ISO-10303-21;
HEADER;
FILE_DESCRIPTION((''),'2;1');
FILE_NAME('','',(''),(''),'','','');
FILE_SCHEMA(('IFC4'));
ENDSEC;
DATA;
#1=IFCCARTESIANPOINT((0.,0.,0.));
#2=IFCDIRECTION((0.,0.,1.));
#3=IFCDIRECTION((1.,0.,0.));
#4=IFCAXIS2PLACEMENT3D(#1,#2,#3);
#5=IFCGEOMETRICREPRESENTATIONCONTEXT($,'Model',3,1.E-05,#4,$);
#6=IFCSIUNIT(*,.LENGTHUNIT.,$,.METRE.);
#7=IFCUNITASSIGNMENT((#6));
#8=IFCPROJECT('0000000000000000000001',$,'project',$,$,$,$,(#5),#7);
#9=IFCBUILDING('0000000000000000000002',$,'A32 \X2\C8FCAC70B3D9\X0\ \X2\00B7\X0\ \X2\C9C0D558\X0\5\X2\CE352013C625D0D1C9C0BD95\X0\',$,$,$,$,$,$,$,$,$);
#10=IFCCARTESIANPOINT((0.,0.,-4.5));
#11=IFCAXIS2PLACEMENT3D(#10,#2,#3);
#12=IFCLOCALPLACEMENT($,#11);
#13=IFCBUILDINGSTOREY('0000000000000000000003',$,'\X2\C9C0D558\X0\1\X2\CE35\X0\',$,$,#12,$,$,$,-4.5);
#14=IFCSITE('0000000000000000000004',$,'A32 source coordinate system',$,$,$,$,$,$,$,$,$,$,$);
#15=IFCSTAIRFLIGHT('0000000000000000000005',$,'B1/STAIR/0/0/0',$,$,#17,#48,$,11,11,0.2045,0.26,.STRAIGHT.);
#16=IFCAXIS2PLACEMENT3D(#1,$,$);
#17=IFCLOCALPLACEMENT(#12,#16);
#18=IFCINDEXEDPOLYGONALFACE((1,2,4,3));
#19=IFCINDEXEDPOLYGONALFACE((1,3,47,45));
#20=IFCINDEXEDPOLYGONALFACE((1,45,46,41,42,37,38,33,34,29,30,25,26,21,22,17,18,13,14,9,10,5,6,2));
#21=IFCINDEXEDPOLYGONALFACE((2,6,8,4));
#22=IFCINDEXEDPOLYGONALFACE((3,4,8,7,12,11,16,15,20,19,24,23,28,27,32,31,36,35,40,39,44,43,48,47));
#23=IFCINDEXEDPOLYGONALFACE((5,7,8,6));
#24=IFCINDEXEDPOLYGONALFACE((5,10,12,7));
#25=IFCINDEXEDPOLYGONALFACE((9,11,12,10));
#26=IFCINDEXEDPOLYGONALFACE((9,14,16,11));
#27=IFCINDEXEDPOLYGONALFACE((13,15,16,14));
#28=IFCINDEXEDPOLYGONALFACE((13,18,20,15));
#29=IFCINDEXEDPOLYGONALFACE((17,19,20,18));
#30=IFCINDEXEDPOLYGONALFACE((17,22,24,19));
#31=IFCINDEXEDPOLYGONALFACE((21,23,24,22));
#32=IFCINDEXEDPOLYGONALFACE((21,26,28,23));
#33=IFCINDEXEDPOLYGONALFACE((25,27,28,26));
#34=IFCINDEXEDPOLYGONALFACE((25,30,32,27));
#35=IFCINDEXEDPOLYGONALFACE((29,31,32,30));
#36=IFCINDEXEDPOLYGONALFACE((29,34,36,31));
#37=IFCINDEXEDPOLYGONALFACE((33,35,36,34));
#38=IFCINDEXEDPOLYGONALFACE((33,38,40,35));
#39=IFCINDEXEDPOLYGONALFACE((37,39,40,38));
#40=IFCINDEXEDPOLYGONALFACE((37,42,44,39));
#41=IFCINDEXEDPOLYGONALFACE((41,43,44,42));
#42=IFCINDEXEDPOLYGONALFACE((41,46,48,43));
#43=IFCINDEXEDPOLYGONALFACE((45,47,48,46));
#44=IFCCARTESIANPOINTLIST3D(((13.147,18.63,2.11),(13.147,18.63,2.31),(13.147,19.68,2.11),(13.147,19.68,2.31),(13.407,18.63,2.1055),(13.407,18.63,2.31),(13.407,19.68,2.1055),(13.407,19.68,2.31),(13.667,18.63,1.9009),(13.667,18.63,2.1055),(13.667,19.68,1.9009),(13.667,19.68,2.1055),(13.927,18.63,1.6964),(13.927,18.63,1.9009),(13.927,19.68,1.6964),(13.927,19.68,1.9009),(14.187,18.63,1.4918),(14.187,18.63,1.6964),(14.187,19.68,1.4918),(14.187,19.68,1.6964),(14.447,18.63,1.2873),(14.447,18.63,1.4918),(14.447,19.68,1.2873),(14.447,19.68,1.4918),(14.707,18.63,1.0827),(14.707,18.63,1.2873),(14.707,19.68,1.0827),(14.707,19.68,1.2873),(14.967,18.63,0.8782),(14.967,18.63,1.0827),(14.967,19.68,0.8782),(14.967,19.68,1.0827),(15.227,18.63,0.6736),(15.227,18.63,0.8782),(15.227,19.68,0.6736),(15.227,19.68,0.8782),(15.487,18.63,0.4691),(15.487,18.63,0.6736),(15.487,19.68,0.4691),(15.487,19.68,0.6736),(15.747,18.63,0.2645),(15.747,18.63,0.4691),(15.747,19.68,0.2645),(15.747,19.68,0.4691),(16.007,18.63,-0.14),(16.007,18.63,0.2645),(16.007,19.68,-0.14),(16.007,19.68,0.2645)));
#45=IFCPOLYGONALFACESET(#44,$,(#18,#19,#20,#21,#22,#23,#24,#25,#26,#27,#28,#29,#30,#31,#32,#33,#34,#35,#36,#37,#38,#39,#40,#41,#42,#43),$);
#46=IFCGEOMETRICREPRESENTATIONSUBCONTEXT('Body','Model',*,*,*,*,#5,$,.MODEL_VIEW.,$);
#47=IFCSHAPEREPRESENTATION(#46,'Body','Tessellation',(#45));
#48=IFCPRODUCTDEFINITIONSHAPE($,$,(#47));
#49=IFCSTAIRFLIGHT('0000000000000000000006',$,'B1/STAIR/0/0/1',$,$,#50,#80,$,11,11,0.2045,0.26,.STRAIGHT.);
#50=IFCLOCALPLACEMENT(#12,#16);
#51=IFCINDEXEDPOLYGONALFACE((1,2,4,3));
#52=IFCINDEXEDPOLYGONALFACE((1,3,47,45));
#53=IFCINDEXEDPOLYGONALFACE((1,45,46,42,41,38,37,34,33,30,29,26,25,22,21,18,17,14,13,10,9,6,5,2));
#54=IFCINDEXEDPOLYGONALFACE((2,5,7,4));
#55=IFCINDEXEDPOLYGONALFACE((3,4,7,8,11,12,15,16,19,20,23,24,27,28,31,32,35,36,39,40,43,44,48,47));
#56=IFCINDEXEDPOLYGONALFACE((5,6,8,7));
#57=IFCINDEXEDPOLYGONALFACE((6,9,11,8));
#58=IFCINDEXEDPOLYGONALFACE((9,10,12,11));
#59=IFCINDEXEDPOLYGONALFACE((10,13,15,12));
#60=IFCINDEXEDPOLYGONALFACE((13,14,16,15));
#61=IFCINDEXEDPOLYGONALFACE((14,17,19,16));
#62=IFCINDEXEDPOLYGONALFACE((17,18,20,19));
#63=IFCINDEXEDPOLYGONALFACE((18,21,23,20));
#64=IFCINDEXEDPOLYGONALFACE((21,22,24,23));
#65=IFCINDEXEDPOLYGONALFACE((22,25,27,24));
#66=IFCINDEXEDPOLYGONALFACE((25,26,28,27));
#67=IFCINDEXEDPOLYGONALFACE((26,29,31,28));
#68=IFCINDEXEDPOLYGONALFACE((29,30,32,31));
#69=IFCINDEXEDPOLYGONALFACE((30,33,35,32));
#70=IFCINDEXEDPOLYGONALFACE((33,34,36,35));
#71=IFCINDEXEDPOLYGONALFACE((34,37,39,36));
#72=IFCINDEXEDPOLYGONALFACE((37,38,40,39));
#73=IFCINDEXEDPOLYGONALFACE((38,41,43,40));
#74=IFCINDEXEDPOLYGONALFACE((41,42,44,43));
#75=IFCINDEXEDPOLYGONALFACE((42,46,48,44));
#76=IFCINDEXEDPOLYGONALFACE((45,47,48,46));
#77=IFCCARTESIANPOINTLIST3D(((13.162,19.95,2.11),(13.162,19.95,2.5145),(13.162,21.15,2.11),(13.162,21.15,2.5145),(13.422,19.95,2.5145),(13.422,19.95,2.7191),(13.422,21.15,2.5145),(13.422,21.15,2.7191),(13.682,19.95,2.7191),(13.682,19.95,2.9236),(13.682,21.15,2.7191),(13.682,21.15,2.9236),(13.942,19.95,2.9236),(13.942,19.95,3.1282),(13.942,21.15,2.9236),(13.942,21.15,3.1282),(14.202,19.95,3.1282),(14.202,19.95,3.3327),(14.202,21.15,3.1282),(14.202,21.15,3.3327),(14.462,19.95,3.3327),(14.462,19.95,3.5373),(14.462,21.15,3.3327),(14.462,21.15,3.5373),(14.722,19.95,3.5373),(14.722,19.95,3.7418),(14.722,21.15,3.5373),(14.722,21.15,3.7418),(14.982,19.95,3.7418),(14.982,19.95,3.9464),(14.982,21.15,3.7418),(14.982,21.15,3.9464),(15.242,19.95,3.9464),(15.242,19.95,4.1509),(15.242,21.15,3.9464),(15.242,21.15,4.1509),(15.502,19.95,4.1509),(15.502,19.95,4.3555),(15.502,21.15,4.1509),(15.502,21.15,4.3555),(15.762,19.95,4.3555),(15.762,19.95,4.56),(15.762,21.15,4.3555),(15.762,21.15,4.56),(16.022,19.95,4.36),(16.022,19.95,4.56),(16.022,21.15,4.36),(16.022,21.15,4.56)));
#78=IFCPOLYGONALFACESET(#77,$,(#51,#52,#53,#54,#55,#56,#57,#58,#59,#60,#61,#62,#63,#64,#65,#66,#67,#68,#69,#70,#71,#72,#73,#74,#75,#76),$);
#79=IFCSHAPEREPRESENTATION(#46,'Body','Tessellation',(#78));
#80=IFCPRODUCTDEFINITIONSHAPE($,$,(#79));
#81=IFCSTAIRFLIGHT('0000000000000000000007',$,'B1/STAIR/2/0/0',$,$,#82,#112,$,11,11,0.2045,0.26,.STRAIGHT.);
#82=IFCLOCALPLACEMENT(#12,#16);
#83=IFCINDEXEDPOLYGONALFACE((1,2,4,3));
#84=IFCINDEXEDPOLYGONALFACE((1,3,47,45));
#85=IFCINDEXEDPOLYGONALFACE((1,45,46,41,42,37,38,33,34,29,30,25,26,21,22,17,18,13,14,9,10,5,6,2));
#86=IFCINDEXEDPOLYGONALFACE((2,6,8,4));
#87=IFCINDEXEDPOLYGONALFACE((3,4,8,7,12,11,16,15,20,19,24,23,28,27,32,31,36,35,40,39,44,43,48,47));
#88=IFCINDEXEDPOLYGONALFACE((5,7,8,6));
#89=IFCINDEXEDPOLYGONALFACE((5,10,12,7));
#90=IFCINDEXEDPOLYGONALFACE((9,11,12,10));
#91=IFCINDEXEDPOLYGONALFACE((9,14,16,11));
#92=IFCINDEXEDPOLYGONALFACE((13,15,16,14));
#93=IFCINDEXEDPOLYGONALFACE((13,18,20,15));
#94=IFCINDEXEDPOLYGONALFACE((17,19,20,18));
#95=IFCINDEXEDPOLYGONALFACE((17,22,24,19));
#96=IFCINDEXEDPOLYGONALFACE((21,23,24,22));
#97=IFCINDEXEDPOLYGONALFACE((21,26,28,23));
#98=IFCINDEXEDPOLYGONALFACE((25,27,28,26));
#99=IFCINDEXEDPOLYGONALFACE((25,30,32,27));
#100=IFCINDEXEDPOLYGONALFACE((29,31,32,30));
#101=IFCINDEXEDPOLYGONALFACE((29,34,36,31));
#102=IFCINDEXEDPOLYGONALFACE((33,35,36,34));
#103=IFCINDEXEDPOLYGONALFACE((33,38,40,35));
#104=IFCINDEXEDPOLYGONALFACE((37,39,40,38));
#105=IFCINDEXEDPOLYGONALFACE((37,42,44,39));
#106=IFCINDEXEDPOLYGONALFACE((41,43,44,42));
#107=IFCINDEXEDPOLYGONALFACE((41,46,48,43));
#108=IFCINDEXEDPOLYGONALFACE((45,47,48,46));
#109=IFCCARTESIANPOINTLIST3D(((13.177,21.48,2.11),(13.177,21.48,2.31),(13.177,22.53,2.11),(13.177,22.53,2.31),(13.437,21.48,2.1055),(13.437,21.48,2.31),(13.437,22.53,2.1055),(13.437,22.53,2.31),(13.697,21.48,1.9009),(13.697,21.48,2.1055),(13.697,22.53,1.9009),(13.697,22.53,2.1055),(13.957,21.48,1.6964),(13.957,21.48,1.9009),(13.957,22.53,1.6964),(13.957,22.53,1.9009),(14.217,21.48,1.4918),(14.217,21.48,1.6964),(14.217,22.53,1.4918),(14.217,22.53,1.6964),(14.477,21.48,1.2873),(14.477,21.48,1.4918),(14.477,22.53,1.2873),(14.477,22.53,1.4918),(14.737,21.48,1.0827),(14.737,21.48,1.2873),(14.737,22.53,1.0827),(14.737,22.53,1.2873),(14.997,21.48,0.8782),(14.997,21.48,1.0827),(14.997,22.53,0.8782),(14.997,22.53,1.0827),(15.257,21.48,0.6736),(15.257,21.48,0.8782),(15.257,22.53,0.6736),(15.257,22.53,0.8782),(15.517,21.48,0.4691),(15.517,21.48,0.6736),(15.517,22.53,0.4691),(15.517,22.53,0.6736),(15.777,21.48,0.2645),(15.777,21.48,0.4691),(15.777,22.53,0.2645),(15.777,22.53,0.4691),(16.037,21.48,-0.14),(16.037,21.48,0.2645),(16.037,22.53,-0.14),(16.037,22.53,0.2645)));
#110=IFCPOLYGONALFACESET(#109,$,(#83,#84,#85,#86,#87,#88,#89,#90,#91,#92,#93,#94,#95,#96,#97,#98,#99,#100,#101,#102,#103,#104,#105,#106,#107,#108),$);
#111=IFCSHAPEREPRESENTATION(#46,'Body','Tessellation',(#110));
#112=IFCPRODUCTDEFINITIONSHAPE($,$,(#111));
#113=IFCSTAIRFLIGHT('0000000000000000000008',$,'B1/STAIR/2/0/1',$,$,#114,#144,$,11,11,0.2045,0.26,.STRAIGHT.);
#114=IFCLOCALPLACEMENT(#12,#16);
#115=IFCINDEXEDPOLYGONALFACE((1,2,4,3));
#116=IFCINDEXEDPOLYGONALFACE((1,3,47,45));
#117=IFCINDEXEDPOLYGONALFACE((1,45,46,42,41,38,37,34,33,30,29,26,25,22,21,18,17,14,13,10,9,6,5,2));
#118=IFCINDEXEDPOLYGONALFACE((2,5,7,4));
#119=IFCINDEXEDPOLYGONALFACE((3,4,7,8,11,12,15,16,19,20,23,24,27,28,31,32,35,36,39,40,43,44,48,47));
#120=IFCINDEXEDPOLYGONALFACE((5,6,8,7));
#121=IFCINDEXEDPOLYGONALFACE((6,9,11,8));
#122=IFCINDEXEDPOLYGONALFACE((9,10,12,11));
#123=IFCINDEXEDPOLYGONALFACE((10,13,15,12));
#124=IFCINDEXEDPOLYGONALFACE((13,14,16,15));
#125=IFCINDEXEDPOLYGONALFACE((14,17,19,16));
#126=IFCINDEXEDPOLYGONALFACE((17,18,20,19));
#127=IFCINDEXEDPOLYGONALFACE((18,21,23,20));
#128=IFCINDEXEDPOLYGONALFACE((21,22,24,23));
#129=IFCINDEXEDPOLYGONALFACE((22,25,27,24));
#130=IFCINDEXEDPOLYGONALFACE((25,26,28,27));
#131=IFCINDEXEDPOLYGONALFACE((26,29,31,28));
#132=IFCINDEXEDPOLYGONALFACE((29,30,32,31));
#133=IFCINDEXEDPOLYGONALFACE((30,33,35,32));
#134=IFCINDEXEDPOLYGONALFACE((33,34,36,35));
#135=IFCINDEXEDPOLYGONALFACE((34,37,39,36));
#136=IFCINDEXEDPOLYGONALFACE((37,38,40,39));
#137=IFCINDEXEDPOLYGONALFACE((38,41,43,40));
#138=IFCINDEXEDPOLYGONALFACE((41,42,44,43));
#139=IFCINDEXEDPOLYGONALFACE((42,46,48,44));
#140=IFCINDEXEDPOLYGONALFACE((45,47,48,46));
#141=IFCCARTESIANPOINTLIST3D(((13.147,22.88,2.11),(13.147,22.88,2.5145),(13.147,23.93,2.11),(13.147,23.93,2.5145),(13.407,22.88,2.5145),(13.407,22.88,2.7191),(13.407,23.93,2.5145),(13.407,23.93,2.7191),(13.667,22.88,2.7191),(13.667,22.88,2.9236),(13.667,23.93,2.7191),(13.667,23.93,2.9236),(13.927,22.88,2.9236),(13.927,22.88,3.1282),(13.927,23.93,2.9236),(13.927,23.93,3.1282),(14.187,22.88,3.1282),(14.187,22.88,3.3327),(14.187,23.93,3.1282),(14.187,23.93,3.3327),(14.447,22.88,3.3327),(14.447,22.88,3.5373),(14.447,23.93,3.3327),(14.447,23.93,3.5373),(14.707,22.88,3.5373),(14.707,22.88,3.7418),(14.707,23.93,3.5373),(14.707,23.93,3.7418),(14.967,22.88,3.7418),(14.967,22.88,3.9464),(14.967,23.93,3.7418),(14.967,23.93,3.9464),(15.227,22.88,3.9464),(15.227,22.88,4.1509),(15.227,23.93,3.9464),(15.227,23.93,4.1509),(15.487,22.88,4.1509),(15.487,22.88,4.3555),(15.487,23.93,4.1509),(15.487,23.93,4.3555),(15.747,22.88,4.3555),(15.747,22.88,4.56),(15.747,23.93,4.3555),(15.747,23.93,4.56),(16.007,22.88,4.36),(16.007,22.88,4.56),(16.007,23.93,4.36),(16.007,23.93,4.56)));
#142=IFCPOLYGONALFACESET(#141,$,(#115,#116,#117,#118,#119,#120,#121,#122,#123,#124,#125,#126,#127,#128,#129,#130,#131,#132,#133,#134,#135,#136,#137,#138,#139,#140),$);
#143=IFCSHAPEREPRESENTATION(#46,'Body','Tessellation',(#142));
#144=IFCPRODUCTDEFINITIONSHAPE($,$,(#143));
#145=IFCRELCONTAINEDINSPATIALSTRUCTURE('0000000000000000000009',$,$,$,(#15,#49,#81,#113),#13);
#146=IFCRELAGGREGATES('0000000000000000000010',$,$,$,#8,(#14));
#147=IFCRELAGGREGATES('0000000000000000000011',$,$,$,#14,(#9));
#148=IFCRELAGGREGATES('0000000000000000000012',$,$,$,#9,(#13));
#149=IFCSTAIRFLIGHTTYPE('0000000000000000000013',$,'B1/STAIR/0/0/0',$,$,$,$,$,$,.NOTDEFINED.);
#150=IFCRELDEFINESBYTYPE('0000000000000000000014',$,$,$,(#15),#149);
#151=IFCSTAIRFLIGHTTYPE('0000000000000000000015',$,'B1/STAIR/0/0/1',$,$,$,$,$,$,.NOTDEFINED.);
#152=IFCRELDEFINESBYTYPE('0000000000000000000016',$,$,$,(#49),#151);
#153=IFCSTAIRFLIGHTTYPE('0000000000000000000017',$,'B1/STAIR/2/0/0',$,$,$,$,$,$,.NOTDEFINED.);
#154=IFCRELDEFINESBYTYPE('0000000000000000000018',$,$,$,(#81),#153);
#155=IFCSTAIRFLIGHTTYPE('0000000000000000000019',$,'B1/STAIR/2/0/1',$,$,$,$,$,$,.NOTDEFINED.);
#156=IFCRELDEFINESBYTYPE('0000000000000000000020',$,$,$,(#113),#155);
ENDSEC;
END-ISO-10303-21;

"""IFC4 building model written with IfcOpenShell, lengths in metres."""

from ifc_helpers import new_model, si_unit, frame, origin, origin_with_axes, place, context, subcontext, project, spatial, polyline, outline, extrude, source, transform, mapped, type_object, type_shapes, element, save


model = new_model("IFC4")

# Units and contexts
model_context = context("Model", 3, precision=1e-05, world=origin_with_axes())
body_context = subcontext(model_context, "Body", "Model", "MODEL_VIEW")
ifc_project = project(units=[si_unit("LENGTHUNIT", "METRE")], contexts=[model_context])

# Site, building, storey
storey_placement = place(None, frame((0.0, 0.0, -4.5), z_axis=(0.0, 0.0, 1.0), x_axis=(1.0, 0.0, 0.0)))
site = spatial("IfcSite", under=ifc_project, Name="A32 source coordinate system")
building = spatial("IfcBuilding", under=site, Name="A32 주거동 · 지하5층–옥탑지붕")
storey = spatial("IfcBuildingStorey", under=building, at=storey_placement, Name="지하1층", Elevation=-4.5)

# Stair flights
stair_flight_type_1 = type_object("IfcStairFlightType", Name="B1/STAIR/0/0/0", PredefinedType="NOTDEFINED")
shared_shape_1 = source(origin(), body_context, "Body", "SweptSolid", [
    extrude(outline(polyline([(0.0, -0.14), (2.86, 2.11), (2.86, 2.31), (2.6, 2.31), (2.6, 2.1055), (2.34, 2.1055), (2.34, 1.9009), (2.08, 1.9009), (2.08, 1.6964), (1.82, 1.6964), (1.82, 1.4918), (1.56, 1.4918), (1.56, 1.2873), (1.3, 1.2873), (1.3, 1.0827), (1.04, 1.0827), (1.04, 0.8782), (0.78, 0.8782), (0.78, 0.6736), (0.52, 0.6736), (0.52, 0.4691), (0.26, 0.4691), (0.26, 0.2645), (0.0, 0.2645), (0.0, -0.14)])), frame((16.007, 18.63, 0.0), z_axis=(0.0, 1.0, 0.0), x_axis=(-1.0, 0.0, 0.0)), (0.0, 0.0, 1.0), 1.05),
])
type_shapes(stair_flight_type_1, [shared_shape_1])
stair_flight_1_placement = place(storey_placement, origin_with_axes())
element("IfcStairFlight", 1, at=stair_flight_1_placement, inside=storey, type_object=stair_flight_type_1, Name="B1/STAIR/0/0/0", NumberOfRisers=11, NumberOfTreads=11, PredefinedType="STRAIGHT", RiserHeight=0.2045, TreadLength=0.26, context=body_context, shape_type="MappedRepresentation", body=[
    mapped(shared_shape_1, transform((0.0, 0.0, 0.0), scale=1.0)),
])
stair_flight_type_2 = type_object("IfcStairFlightType", Name="B1/STAIR/0/0/1", PredefinedType="NOTDEFINED")
shared_shape_2 = source(origin(), body_context, "Body", "SweptSolid", [
    extrude(outline(polyline([(0.0, 2.11), (2.86, 4.36), (2.86, 4.56), (2.6, 4.56), (2.6, 4.3555), (2.34, 4.3555), (2.34, 4.1509), (2.08, 4.1509), (2.08, 3.9464), (1.82, 3.9464), (1.82, 3.7418), (1.56, 3.7418), (1.56, 3.5373), (1.3, 3.5373), (1.3, 3.3327), (1.04, 3.3327), (1.04, 3.1282), (0.78, 3.1282), (0.78, 2.9236), (0.52, 2.9236), (0.52, 2.7191), (0.26, 2.7191), (0.26, 2.5145), (0.0, 2.5145), (0.0, 2.11)])), frame((13.162, 21.15, 0.0), z_axis=(0.0, -1.0, 0.0), x_axis=(1.0, 0.0, 0.0)), (0.0, 0.0, 1.0), 1.2),
])
type_shapes(stair_flight_type_2, [shared_shape_2])
stair_flight_2_placement = place(storey_placement, origin_with_axes())
element("IfcStairFlight", 2, at=stair_flight_2_placement, inside=storey, type_object=stair_flight_type_2, Name="B1/STAIR/0/0/1", NumberOfRisers=11, NumberOfTreads=11, PredefinedType="STRAIGHT", RiserHeight=0.2045, TreadLength=0.26, context=body_context, shape_type="MappedRepresentation", body=[
    mapped(shared_shape_2, transform((0.0, 0.0, 0.0), scale=1.0)),
])
stair_flight_type_3 = type_object("IfcStairFlightType", Name="B1/STAIR/2/0/0", PredefinedType="NOTDEFINED")
shared_shape_3 = source(origin(), body_context, "Body", "SweptSolid", [
    extrude(outline(polyline([(0.0, -0.14), (2.86, 2.11), (2.86, 2.31), (2.6, 2.31), (2.6, 2.1055), (2.34, 2.1055), (2.34, 1.9009), (2.08, 1.9009), (2.08, 1.6964), (1.82, 1.6964), (1.82, 1.4918), (1.56, 1.4918), (1.56, 1.2873), (1.3, 1.2873), (1.3, 1.0827), (1.04, 1.0827), (1.04, 0.8782), (0.78, 0.8782), (0.78, 0.6736), (0.52, 0.6736), (0.52, 0.4691), (0.26, 0.4691), (0.26, 0.2645), (0.0, 0.2645), (0.0, -0.14)])), frame((16.037, 21.48, 0.0), z_axis=(0.0, 1.0, 0.0), x_axis=(-1.0, 0.0, 0.0)), (0.0, 0.0, 1.0), 1.05),
])
type_shapes(stair_flight_type_3, [shared_shape_3])
stair_flight_3_placement = place(storey_placement, origin_with_axes())
element("IfcStairFlight", 3, at=stair_flight_3_placement, inside=storey, type_object=stair_flight_type_3, Name="B1/STAIR/2/0/0", NumberOfRisers=11, NumberOfTreads=11, PredefinedType="STRAIGHT", RiserHeight=0.2045, TreadLength=0.26, context=body_context, shape_type="MappedRepresentation", body=[
    mapped(shared_shape_3, transform((0.0, 0.0, 0.0), scale=1.0)),
])
stair_flight_type_4 = type_object("IfcStairFlightType", Name="B1/STAIR/2/0/1", PredefinedType="NOTDEFINED")
shared_shape_4 = source(origin(), body_context, "Body", "SweptSolid", [
    extrude(outline(polyline([(0.0, 2.11), (2.86, 4.36), (2.86, 4.56), (2.6, 4.56), (2.6, 4.3555), (2.34, 4.3555), (2.34, 4.1509), (2.08, 4.1509), (2.08, 3.9464), (1.82, 3.9464), (1.82, 3.7418), (1.56, 3.7418), (1.56, 3.5373), (1.3, 3.5373), (1.3, 3.3327), (1.04, 3.3327), (1.04, 3.1282), (0.78, 3.1282), (0.78, 2.9236), (0.52, 2.9236), (0.52, 2.7191), (0.26, 2.7191), (0.26, 2.5145), (0.0, 2.5145), (0.0, 2.11)])), frame((13.147, 23.93, 0.0), z_axis=(0.0, -1.0, 0.0), x_axis=(1.0, 0.0, 0.0)), (0.0, 0.0, 1.0), 1.05),
])
type_shapes(stair_flight_type_4, [shared_shape_4])
stair_flight_4_placement = place(storey_placement, origin_with_axes())
element("IfcStairFlight", 4, at=stair_flight_4_placement, inside=storey, type_object=stair_flight_type_4, Name="B1/STAIR/2/0/1", NumberOfRisers=11, NumberOfTreads=11, PredefinedType="STRAIGHT", RiserHeight=0.2045, TreadLength=0.26, context=body_context, shape_type="MappedRepresentation", body=[
    mapped(shared_shape_4, transform((0.0, 0.0, 0.0), scale=1.0)),
])

save(model, "model.ifc")
